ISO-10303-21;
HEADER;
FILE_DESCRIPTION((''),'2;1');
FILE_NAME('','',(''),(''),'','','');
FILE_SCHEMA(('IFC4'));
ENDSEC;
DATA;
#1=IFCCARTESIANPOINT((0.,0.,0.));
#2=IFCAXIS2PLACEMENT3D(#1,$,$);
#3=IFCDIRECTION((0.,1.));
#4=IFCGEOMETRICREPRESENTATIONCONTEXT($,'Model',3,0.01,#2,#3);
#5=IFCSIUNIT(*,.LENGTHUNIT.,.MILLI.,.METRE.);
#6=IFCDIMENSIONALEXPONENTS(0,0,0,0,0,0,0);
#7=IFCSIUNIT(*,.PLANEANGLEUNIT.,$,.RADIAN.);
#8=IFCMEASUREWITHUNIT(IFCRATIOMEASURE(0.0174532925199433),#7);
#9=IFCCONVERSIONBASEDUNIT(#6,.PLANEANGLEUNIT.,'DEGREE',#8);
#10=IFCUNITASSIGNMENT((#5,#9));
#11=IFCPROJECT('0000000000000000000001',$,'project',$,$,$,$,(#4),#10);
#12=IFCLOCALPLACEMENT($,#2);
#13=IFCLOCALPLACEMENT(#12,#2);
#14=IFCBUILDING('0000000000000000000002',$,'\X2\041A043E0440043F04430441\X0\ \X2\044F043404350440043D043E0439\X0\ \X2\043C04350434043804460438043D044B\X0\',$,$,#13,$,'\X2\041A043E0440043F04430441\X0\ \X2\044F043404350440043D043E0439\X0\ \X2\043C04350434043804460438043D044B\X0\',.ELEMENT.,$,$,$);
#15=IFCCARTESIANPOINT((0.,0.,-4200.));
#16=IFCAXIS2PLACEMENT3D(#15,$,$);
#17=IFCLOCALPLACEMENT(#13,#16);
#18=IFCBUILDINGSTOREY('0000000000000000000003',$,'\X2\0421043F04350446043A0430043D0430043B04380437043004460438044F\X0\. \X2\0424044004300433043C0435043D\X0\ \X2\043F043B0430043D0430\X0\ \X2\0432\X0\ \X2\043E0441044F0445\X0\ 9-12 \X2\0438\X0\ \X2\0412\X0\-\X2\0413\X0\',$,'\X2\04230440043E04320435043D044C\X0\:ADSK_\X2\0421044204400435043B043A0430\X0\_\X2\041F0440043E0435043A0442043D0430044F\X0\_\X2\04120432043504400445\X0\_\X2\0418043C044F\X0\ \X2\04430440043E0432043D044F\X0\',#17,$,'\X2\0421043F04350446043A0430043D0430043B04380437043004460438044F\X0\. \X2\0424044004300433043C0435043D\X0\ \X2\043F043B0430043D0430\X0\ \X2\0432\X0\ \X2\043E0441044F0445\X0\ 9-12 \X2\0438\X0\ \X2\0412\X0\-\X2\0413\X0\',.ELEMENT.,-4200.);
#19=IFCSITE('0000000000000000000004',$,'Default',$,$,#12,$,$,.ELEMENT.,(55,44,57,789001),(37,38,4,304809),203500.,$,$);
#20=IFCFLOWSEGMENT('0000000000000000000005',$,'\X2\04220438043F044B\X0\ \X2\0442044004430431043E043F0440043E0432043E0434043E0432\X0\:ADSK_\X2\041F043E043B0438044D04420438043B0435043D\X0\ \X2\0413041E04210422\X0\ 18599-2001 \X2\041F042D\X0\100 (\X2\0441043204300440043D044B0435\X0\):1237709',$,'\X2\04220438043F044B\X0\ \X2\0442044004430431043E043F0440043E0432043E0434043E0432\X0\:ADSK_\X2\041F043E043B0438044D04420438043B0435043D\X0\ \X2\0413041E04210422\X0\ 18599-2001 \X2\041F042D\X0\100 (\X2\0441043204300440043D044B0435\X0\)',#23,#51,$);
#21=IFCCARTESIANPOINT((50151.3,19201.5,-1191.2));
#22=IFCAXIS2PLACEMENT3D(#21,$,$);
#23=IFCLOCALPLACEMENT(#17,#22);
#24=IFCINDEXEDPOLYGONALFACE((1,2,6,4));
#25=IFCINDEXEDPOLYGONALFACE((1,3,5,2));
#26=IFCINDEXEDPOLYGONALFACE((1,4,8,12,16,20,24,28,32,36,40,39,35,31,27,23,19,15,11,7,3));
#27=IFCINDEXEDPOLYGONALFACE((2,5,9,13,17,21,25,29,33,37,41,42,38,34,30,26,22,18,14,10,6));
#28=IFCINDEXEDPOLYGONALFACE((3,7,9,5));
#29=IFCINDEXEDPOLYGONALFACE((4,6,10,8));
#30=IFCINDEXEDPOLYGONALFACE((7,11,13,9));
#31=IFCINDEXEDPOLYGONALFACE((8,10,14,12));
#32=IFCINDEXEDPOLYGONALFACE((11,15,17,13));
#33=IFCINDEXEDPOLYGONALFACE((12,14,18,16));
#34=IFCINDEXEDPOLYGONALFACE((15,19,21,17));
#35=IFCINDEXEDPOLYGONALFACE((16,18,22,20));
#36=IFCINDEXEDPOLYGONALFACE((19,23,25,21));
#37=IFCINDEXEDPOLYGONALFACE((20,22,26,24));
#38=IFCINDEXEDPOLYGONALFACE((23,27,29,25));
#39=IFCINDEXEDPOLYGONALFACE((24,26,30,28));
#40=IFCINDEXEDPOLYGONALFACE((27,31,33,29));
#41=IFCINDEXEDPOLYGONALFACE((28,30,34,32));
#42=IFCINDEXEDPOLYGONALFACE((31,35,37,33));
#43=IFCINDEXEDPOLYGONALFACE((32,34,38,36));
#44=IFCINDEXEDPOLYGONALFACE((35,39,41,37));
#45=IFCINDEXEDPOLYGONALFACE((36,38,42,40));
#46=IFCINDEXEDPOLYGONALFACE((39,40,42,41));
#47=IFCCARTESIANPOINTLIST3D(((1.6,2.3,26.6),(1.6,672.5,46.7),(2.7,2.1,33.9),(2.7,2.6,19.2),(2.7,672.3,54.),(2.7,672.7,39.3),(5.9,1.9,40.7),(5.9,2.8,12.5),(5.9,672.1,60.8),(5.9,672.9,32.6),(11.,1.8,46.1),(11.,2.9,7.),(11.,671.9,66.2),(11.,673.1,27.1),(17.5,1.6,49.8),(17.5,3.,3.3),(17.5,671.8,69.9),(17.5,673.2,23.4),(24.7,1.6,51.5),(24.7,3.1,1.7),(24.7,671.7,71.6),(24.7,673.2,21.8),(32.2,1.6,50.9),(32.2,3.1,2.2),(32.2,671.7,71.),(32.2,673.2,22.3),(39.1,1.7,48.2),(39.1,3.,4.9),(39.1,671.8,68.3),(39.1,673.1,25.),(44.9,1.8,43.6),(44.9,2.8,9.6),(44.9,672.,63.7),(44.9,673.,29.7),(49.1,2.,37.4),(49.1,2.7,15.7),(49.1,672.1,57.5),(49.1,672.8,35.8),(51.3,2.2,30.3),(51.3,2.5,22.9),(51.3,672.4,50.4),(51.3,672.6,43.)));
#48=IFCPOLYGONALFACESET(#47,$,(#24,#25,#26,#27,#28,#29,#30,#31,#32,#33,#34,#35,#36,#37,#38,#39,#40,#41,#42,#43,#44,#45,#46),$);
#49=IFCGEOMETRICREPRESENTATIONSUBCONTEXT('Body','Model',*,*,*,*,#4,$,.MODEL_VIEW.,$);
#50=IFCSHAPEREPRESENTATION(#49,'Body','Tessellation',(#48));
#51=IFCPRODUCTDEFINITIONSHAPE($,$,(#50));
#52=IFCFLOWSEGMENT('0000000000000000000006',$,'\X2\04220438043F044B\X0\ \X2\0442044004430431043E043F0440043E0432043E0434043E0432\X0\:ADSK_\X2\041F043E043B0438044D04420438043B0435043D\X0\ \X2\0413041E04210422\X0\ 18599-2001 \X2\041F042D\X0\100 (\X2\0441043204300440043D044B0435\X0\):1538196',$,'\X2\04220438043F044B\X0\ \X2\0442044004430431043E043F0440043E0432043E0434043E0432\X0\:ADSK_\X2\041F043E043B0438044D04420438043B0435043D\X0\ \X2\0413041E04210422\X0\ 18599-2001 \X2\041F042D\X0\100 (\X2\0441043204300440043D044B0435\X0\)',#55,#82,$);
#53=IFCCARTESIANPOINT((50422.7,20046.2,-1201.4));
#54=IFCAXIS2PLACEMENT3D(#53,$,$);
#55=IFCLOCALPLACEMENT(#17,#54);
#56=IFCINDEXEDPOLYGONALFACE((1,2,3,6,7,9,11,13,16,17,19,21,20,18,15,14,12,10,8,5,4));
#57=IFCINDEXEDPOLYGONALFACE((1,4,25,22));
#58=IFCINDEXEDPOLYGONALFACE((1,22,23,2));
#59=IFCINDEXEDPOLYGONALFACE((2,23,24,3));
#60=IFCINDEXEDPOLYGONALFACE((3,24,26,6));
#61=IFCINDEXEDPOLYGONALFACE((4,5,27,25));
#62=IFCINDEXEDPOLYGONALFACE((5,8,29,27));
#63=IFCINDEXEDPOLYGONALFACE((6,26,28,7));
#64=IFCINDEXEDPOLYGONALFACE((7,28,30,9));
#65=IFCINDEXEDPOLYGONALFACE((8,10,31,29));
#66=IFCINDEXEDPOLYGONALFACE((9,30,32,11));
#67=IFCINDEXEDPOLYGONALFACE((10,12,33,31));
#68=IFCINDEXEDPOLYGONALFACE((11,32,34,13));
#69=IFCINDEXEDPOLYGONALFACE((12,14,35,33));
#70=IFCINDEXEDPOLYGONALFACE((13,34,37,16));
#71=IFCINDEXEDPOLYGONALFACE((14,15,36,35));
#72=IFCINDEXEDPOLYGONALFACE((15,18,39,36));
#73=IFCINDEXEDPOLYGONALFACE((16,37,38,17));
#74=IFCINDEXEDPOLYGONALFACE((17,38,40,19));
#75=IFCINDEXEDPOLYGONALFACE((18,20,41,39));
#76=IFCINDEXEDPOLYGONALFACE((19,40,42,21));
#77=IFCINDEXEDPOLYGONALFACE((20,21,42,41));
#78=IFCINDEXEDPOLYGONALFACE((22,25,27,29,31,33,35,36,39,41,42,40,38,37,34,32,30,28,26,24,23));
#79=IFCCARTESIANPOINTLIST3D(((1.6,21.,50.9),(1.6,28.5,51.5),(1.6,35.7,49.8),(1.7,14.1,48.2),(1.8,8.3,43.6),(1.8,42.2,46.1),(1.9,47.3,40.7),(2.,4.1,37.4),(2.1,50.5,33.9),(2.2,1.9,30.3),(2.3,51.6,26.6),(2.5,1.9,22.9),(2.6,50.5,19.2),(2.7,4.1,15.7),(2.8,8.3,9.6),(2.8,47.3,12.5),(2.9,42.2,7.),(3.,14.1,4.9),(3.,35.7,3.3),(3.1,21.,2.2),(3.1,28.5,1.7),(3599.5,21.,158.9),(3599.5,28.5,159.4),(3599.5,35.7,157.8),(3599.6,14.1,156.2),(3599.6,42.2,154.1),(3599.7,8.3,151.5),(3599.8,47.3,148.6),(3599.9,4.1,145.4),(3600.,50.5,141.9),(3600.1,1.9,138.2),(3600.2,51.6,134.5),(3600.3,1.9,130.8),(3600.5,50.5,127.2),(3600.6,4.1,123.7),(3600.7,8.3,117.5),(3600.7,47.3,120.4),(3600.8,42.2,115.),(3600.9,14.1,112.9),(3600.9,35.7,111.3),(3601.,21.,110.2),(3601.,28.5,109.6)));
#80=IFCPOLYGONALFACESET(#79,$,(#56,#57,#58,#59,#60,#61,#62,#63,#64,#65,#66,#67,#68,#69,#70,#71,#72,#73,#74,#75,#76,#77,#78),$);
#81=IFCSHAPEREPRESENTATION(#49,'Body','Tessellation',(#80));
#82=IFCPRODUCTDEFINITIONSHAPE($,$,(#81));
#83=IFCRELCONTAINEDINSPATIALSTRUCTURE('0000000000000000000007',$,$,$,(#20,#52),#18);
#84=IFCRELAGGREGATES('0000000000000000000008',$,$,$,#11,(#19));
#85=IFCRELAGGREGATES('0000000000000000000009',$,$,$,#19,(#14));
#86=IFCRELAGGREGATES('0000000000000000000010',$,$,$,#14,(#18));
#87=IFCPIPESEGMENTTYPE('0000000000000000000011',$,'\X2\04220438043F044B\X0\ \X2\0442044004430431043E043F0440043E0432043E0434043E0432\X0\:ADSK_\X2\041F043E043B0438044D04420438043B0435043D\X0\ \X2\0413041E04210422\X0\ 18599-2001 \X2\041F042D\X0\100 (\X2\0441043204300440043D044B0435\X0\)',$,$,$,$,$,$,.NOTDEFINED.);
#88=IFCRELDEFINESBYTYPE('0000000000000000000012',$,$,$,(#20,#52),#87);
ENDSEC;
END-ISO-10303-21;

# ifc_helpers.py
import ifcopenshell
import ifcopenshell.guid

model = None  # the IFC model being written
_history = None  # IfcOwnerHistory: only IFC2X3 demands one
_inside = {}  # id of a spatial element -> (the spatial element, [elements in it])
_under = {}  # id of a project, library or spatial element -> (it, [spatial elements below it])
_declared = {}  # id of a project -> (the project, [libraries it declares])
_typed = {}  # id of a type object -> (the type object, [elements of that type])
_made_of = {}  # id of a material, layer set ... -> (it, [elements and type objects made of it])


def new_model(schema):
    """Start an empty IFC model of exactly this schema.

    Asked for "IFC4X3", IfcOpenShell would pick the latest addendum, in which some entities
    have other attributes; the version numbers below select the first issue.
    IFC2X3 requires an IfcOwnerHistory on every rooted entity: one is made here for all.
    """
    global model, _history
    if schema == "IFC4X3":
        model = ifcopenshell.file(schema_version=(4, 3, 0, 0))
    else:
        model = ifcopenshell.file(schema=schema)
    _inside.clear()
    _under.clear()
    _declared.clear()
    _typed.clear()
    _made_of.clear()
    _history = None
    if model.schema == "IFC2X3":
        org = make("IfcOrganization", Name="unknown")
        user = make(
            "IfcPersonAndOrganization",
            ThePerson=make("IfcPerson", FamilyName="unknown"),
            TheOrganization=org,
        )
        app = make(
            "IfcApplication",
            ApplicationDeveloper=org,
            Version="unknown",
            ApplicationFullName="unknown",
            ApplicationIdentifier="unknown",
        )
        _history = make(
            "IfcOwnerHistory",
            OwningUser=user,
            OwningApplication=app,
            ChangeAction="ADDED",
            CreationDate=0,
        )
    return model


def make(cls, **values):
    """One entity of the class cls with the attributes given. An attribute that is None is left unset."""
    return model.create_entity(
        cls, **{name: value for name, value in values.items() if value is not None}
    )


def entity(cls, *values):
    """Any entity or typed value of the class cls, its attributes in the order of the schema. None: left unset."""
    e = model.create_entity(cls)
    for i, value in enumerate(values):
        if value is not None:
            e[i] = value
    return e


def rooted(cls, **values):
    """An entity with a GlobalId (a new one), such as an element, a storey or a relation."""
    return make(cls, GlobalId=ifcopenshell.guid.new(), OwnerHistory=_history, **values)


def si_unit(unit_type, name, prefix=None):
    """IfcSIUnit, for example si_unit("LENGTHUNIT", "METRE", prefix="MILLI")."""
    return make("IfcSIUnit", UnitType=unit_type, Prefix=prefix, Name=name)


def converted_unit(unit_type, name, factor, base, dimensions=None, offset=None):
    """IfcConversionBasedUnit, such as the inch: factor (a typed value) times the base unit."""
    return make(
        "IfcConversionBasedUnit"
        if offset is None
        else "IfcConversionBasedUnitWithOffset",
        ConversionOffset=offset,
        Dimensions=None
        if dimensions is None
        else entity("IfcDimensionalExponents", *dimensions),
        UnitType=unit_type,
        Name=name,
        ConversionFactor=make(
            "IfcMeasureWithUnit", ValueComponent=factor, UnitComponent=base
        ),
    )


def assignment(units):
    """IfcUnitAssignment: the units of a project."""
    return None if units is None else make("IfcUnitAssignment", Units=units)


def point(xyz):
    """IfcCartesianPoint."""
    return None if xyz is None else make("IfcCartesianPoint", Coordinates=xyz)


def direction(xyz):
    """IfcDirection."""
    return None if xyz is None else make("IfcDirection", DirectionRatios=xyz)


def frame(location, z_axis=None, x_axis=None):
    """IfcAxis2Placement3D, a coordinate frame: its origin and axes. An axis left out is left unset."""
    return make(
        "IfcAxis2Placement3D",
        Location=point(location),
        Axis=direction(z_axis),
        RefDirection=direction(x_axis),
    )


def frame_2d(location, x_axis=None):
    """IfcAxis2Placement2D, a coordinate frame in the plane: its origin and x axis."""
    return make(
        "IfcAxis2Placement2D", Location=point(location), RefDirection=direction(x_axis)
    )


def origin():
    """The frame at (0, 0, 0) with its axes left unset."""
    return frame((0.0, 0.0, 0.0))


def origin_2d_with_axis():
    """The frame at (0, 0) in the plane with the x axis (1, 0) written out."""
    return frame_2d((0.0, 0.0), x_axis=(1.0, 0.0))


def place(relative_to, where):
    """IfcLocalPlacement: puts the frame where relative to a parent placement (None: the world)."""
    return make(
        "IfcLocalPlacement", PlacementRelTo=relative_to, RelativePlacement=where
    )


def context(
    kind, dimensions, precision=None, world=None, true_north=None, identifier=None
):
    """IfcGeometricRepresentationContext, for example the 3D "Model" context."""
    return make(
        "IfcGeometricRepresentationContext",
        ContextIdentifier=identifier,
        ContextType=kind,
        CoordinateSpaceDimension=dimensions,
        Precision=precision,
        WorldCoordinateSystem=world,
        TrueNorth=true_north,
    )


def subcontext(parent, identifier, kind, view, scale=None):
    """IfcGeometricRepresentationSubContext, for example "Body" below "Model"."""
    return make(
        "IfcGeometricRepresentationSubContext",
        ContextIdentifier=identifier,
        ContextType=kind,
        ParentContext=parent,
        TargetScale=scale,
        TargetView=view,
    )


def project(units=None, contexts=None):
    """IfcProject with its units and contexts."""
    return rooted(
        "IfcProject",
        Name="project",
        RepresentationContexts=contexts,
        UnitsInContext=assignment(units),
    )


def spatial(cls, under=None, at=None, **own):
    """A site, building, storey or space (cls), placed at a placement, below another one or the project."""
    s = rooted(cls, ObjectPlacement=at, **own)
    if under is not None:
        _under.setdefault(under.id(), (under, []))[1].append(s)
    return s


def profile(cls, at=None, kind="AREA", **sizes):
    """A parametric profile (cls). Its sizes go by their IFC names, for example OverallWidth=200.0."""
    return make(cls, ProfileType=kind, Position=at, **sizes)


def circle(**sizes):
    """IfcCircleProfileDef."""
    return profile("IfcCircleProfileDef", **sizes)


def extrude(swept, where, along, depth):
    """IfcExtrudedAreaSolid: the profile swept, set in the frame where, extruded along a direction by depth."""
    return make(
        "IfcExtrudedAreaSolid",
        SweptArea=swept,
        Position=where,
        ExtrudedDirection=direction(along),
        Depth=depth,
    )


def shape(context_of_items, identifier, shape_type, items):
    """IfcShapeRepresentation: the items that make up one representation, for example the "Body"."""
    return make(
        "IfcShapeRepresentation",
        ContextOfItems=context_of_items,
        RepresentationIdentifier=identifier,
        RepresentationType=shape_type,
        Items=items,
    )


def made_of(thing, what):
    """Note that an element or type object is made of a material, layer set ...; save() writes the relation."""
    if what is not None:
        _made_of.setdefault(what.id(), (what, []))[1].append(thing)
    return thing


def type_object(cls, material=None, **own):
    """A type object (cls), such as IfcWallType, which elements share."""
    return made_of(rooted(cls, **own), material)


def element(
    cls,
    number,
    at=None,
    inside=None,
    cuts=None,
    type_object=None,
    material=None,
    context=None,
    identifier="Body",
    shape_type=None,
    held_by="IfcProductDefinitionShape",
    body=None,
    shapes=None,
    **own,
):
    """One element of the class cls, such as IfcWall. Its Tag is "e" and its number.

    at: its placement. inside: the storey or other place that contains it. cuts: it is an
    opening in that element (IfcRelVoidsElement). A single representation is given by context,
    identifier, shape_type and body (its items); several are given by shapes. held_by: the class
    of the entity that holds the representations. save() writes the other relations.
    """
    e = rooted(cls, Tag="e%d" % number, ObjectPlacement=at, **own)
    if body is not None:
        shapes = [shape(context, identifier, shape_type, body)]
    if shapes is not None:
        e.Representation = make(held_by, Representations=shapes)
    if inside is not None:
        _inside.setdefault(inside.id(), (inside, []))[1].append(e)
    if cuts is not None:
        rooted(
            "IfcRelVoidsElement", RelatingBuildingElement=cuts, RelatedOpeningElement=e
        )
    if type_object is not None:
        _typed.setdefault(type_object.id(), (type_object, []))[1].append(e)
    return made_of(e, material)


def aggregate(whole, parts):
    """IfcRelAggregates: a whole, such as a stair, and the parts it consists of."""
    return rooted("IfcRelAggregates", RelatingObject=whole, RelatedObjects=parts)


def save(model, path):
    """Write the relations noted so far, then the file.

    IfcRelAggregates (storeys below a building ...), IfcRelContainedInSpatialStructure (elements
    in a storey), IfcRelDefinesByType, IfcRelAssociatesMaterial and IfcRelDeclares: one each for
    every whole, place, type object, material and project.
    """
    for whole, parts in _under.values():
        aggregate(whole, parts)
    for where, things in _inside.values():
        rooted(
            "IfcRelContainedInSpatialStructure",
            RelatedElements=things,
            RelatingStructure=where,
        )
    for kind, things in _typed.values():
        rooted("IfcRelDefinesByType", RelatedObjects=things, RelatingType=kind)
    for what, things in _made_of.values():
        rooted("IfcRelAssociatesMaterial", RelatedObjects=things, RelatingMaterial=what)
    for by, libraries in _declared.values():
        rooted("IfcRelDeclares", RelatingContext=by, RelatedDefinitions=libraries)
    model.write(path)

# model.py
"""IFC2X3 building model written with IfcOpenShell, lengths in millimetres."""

from ifc_helpers import new_model, entity, si_unit, converted_unit, direction, frame, origin, origin_2d_with_axis, place, context, subcontext, project, spatial, circle, extrude, type_object, element, save


model = new_model("IFC2X3")

# Units and contexts
model_context = context("Model", 3, precision=0.01, world=origin(), true_north=direction((0.0, 1.0)))
body_context = subcontext(model_context, "Body", "Model", "MODEL_VIEW")
ifc_project = project(units=[si_unit("LENGTHUNIT", "METRE", prefix="MILLI"), converted_unit("PLANEANGLEUNIT", "DEGREE", entity("IfcRatioMeasure", 0.0174532925199433), si_unit("PLANEANGLEUNIT", "RADIAN"), dimensions=[0, 0, 0, 0, 0, 0, 0])], contexts=[model_context])

# Site, building, storey
site_placement = place(None, origin())
site = spatial("IfcSite", under=ifc_project, at=site_placement, Name="Default", CompositionType="ELEMENT", RefLatitude=(55, 44, 57, 789001), RefLongitude=(37, 38, 4, 304809), RefElevation=203500.0)
building_placement = place(site_placement, origin())
building = spatial("IfcBuilding", under=site, at=building_placement, Name="Корпус ядерной медицины", LongName="Корпус ядерной медицины", CompositionType="ELEMENT")
storey_placement = place(building_placement, frame((0.0, 0.0, -4200.0)))
storey = spatial("IfcBuildingStorey", under=building, at=storey_placement, Name="Спецканализация. Фрагмен плана в осях 9-12 и В-Г", ObjectType="Уровень:ADSK_Стрелка_Проектная_Вверх_Имя уровня", LongName="Спецканализация. Фрагмен плана в осях 9-12 и В-Г", CompositionType="ELEMENT", Elevation=-4200.0)

# Flow segments
pipe_segment_type = type_object("IfcPipeSegmentType", Name="Типы трубопроводов:ADSK_Полиэтилен ГОСТ 18599-2001 ПЭ100 (сварные)", PredefinedType="NOTDEFINED")
flow_segment_1_placement = place(storey_placement, frame((50151.3, 19201.5, -1191.2)))
element("IfcFlowSegment", 1, at=flow_segment_1_placement, inside=storey, type_object=pipe_segment_type, Name="Типы трубопроводов:ADSK_Полиэтилен ГОСТ 18599-2001 ПЭ100 (сварные):1237709", ObjectType="Типы трубопроводов:ADSK_Полиэтилен ГОСТ 18599-2001 ПЭ100 (сварные)", context=body_context, shape_type="SweptSolid", body=[
    extrude(circle(Radius=25.0, at=origin_2d_with_axis()), frame((26.6, 2.3, 26.6), z_axis=(0.0, 0.99955, 0.029987), x_axis=(-1.0, 0.0, 0.0)), (0.0, 0.0, 1.0), 670.4),
])
flow_segment_2_placement = place(storey_placement, frame((50422.7, 20046.2, -1201.4)))
element("IfcFlowSegment", 2, at=flow_segment_2_placement, inside=storey, type_object=pipe_segment_type, Name="Типы трубопроводов:ADSK_Полиэтилен ГОСТ 18599-2001 ПЭ100 (сварные):1538196", ObjectType="Типы трубопроводов:ADSK_Полиэтилен ГОСТ 18599-2001 ПЭ100 (сварные)", context=body_context, shape_type="SweptSolid", body=[
    extrude(circle(Radius=25.0, at=origin_2d_with_axis()), frame((2.3, 26.6, 26.6), z_axis=(0.99955, 0.0, 0.029987), x_axis=(0.0, 1.0, 0.0)), (0.0, 0.0, 1.0), 3599.5),
])

save(model, "model.ifc")
